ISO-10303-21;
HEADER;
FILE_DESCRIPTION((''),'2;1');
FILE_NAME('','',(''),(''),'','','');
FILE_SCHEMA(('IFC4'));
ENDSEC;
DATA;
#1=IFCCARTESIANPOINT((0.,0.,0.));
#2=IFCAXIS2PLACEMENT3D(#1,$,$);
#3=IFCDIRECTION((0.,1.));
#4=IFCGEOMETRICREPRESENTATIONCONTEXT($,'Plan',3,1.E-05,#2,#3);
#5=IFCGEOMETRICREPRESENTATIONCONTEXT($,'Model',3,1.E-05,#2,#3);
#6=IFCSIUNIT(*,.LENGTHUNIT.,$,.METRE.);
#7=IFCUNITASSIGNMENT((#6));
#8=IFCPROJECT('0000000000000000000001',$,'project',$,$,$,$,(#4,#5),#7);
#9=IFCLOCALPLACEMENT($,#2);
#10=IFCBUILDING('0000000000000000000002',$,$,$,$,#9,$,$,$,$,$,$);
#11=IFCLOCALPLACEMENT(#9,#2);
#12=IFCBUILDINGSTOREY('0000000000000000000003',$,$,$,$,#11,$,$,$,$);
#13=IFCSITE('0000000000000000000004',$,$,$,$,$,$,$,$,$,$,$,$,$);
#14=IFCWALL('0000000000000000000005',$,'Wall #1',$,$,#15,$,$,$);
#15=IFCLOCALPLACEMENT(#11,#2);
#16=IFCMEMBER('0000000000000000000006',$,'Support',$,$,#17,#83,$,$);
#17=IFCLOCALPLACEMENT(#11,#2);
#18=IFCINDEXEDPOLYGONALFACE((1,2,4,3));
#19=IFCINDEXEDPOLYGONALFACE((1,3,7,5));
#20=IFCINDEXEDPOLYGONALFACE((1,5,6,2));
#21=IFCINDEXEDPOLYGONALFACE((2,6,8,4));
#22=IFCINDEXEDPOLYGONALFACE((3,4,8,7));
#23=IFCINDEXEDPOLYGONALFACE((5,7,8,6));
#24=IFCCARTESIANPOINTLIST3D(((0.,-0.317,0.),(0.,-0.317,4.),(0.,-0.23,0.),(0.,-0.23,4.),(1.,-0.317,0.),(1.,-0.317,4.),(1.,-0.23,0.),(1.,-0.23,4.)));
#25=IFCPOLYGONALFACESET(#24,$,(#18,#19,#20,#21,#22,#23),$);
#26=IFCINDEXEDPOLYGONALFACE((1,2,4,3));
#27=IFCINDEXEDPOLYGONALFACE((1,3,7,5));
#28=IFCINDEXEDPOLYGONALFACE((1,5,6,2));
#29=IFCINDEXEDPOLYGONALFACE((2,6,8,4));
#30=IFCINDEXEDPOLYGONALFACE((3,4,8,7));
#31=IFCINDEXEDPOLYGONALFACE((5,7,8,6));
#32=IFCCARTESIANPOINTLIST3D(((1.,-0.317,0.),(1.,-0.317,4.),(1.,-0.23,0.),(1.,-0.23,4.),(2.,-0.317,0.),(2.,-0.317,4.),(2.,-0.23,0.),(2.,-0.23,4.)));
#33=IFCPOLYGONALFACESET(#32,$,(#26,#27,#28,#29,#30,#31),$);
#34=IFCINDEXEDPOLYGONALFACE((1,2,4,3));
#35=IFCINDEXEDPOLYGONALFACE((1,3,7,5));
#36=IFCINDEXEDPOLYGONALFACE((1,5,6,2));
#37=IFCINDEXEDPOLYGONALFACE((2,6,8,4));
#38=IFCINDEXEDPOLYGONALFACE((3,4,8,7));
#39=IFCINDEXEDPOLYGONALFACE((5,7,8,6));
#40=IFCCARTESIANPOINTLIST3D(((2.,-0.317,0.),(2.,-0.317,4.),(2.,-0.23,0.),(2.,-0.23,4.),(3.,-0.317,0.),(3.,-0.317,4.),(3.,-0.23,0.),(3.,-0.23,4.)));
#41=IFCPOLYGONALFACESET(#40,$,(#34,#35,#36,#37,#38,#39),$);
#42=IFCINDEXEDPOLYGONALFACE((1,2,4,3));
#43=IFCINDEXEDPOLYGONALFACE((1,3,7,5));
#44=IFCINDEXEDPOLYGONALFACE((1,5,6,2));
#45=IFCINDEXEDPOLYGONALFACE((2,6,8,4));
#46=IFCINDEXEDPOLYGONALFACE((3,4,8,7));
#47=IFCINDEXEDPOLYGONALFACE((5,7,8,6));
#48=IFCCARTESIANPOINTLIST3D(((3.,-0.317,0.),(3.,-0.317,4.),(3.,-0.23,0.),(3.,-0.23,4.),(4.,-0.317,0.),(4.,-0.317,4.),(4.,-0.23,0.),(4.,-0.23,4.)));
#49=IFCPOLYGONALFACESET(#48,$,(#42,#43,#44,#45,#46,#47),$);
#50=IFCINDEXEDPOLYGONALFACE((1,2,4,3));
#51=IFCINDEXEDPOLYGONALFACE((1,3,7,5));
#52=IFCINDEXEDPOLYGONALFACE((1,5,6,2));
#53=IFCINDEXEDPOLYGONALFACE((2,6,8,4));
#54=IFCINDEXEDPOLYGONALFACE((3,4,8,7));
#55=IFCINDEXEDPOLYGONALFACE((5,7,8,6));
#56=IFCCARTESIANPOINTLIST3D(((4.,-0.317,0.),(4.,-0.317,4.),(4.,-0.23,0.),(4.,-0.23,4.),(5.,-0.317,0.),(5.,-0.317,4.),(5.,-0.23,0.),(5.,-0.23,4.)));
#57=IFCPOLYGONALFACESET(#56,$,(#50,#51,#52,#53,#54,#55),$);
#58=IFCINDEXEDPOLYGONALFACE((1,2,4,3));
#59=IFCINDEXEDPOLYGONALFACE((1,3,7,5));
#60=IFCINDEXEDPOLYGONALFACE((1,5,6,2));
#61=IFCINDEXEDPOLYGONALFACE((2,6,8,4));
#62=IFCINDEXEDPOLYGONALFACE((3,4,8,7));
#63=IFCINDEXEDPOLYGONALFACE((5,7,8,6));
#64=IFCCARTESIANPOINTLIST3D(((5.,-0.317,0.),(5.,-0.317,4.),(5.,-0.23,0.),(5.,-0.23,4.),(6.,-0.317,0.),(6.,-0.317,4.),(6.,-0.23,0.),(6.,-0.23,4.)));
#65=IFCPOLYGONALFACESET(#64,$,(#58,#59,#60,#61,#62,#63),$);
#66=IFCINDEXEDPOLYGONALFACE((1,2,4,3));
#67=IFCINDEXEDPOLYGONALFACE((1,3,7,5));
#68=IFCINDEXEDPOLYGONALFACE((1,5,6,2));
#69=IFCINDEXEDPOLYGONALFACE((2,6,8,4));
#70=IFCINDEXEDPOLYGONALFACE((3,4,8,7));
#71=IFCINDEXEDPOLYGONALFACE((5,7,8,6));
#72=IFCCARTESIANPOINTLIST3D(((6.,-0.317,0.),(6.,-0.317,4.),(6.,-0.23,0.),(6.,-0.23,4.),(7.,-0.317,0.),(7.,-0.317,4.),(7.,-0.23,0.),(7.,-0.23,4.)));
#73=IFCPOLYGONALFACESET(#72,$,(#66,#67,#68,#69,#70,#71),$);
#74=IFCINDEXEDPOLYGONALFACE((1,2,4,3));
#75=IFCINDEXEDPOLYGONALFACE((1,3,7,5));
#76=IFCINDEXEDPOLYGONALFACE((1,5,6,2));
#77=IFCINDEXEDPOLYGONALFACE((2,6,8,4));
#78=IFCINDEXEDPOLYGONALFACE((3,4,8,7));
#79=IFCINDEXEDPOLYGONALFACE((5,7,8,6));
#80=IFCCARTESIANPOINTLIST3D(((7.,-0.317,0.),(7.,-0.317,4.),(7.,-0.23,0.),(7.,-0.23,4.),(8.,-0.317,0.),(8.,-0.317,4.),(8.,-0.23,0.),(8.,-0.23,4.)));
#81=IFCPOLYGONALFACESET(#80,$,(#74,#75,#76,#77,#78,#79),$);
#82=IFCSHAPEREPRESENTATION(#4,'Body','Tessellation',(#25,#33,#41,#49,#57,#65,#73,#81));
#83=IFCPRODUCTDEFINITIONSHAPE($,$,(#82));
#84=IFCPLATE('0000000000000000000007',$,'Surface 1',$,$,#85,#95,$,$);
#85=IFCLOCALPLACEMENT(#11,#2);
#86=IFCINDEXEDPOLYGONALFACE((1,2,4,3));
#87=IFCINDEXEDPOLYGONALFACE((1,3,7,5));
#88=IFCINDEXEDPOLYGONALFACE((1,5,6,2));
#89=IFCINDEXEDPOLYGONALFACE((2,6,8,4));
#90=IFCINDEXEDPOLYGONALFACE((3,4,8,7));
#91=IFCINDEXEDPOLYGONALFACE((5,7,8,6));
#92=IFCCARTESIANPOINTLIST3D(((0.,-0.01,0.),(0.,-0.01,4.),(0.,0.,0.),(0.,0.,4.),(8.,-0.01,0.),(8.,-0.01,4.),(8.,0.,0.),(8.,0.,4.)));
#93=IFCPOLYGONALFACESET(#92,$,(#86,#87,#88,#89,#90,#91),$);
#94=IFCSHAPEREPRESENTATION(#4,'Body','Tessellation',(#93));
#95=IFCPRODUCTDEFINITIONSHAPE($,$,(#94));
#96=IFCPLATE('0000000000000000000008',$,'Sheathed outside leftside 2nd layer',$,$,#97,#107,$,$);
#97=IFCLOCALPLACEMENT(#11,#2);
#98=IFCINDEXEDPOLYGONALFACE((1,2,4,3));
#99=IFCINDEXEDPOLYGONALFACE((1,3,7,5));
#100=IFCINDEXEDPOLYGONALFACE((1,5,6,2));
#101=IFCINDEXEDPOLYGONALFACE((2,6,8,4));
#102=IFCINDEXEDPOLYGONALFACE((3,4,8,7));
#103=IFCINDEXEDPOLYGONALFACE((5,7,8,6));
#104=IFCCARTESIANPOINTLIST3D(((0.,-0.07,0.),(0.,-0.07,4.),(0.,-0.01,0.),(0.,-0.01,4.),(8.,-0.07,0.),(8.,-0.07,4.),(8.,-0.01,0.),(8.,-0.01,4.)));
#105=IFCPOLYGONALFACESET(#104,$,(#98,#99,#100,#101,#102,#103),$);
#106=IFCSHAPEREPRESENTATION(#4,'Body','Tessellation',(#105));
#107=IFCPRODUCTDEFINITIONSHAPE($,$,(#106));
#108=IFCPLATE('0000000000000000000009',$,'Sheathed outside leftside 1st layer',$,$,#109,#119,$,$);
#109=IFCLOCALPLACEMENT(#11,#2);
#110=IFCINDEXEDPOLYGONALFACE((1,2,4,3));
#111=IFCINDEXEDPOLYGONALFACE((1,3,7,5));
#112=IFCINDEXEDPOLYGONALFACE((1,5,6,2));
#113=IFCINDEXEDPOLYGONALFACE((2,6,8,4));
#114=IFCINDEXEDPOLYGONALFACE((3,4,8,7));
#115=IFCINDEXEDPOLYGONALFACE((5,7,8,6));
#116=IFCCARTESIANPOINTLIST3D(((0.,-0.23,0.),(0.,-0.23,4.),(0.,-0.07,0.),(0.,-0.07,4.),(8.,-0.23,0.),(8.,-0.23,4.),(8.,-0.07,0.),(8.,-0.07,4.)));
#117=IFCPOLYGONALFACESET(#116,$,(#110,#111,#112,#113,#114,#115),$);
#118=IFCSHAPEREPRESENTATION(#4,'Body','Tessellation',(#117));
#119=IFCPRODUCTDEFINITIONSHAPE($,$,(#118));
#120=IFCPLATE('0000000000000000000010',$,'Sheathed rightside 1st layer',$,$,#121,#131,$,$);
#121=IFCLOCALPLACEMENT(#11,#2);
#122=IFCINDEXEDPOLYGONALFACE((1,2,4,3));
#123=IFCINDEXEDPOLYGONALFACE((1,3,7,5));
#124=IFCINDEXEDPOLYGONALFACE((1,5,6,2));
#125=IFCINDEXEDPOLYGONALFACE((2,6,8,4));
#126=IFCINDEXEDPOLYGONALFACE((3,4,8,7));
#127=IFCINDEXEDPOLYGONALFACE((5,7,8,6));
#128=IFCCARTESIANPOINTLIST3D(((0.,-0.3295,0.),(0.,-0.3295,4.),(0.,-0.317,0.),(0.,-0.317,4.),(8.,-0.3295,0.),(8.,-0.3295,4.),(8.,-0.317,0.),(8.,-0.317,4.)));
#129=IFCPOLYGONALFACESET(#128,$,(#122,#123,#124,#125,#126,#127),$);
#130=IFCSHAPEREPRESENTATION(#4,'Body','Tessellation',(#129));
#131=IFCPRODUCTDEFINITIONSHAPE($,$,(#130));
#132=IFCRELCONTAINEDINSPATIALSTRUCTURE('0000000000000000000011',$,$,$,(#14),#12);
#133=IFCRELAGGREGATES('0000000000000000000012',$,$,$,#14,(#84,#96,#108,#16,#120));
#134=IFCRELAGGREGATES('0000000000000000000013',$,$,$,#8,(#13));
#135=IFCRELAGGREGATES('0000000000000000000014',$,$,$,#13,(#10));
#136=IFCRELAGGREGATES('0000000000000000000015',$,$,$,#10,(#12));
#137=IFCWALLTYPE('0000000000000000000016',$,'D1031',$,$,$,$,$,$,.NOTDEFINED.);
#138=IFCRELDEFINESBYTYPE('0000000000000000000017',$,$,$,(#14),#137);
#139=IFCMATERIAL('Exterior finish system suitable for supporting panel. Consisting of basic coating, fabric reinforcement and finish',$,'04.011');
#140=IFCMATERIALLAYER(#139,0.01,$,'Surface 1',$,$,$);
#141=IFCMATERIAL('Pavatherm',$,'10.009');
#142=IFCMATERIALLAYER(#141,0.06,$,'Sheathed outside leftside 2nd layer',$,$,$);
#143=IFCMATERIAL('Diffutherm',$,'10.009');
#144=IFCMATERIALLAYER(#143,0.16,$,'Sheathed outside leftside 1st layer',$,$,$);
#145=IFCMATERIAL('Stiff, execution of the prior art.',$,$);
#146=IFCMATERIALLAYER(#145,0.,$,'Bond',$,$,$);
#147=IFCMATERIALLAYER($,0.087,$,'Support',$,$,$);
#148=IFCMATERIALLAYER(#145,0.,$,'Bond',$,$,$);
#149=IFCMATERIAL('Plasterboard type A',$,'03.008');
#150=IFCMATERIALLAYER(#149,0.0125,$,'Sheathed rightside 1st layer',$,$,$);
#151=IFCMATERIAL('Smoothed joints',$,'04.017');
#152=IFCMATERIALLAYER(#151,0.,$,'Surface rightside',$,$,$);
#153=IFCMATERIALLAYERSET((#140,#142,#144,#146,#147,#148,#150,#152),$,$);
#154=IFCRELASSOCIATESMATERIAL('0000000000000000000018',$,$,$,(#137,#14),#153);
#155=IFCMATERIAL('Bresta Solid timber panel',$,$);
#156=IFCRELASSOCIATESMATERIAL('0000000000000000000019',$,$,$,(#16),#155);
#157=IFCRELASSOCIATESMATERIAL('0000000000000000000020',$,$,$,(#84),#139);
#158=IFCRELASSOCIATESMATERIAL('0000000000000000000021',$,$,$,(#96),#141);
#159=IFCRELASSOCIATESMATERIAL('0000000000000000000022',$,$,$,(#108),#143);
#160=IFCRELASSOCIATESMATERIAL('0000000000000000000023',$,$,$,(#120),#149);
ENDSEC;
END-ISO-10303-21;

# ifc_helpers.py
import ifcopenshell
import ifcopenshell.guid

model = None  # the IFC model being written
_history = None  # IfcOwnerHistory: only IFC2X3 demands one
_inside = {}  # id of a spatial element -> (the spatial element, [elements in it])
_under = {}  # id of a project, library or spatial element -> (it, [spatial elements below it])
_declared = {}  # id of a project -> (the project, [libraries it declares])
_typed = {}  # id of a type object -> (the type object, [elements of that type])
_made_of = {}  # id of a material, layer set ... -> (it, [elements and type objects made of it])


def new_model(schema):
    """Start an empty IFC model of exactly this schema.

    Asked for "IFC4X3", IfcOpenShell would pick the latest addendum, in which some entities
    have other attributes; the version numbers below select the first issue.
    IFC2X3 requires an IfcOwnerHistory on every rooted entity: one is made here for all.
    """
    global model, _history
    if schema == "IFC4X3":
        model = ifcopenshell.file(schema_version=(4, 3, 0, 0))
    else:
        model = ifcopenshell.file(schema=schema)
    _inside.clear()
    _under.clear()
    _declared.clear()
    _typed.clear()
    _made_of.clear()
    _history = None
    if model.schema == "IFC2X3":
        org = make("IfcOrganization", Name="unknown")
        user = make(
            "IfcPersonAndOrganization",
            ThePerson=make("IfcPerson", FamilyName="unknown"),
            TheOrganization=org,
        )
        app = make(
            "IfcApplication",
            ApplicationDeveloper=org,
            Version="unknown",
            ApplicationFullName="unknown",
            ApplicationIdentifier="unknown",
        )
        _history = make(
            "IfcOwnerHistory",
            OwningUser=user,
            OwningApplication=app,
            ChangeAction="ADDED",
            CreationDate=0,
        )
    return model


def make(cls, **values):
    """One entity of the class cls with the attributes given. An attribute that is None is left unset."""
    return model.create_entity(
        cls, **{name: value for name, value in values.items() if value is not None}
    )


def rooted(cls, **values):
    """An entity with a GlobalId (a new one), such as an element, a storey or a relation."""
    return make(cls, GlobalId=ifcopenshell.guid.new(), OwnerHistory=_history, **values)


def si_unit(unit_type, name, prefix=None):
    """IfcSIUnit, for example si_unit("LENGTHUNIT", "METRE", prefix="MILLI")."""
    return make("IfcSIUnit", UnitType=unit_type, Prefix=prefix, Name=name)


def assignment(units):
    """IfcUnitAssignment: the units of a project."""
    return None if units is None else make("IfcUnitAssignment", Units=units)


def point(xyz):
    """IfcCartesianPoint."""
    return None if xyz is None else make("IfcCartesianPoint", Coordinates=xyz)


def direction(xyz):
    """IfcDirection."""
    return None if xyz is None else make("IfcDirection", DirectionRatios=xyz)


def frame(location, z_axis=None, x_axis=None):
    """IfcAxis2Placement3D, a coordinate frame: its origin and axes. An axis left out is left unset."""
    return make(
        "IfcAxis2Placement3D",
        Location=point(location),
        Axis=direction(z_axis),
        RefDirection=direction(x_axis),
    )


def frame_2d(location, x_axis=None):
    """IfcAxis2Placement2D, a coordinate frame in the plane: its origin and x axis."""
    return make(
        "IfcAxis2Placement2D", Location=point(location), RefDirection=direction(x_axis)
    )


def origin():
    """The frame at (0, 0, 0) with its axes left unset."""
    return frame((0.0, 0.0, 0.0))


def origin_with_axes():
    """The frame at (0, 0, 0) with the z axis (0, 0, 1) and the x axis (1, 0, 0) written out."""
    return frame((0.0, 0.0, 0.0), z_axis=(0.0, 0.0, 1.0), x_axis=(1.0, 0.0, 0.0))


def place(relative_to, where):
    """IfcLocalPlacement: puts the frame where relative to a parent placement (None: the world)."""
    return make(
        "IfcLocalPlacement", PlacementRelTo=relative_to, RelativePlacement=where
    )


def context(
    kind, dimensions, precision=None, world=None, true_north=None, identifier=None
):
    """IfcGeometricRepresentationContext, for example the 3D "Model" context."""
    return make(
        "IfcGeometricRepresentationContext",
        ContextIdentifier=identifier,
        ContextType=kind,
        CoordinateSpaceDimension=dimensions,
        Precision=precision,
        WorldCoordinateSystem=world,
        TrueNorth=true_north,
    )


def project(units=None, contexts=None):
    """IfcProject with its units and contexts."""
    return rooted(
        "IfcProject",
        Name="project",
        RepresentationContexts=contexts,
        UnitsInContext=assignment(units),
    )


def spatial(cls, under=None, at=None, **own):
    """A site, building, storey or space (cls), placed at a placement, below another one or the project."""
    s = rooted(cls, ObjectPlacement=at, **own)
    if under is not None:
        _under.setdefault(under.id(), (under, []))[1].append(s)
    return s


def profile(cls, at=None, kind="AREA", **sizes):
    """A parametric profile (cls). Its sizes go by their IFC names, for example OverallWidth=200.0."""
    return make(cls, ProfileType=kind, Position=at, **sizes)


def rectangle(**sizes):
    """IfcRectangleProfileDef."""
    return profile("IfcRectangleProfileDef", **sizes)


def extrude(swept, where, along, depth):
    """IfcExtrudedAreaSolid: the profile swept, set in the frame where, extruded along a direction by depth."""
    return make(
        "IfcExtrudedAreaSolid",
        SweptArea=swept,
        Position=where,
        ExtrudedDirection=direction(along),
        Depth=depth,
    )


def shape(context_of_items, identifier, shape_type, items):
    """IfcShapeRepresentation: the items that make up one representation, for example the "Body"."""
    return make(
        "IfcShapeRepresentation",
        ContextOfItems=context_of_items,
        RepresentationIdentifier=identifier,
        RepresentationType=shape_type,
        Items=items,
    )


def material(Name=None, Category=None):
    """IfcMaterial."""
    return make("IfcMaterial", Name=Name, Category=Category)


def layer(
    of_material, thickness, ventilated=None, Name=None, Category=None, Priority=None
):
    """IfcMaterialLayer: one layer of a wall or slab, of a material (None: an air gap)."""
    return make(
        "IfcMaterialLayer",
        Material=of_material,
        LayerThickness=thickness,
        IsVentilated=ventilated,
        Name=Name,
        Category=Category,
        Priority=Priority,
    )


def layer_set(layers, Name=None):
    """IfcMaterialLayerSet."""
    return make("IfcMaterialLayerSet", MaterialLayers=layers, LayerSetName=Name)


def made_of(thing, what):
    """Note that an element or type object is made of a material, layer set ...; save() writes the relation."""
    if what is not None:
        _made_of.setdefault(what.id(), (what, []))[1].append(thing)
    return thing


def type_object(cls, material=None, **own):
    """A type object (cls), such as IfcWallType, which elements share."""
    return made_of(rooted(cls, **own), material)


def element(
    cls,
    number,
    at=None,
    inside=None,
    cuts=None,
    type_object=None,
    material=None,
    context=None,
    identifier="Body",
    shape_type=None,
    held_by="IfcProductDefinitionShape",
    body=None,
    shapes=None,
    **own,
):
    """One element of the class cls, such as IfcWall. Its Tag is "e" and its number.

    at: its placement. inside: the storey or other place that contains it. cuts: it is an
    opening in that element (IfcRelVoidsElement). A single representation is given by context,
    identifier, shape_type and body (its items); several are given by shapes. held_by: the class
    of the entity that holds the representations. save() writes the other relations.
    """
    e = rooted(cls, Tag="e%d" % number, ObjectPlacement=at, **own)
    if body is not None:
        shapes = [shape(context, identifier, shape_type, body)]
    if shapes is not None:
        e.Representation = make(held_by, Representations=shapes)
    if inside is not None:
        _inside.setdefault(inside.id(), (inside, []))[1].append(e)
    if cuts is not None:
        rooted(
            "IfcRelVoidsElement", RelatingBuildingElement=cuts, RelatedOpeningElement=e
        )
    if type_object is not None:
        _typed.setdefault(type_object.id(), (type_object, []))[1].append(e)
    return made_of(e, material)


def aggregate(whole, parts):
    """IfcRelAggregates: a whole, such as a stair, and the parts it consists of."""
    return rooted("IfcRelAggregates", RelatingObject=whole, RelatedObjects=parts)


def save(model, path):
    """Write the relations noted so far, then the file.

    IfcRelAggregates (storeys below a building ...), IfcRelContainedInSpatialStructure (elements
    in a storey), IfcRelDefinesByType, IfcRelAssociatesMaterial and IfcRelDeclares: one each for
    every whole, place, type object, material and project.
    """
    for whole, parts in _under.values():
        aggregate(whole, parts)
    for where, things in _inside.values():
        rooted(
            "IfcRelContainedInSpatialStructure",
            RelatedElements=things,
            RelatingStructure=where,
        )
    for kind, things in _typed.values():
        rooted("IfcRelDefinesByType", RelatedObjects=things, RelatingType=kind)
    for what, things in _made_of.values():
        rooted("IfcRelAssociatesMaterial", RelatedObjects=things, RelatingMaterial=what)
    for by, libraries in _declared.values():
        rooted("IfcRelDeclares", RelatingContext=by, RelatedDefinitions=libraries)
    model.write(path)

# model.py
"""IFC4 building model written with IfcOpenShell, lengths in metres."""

from ifc_helpers import new_model, si_unit, direction, frame, frame_2d, origin, origin_with_axes, place, context, project, spatial, rectangle, extrude, material, layer, layer_set, type_object, element, aggregate, save


model = new_model("IFC4")

# Units and contexts
plan_context = context("Plan", 3, precision=1e-05, world=origin(), true_north=direction((0.0, 1.0)))
model_context = context("Model", 3, precision=1e-05, world=origin(), true_north=direction((0.0, 1.0)))
ifc_project = project(units=[si_unit("LENGTHUNIT", "METRE")], contexts=[plan_context, model_context])

# Site, building, storey
site = spatial("IfcSite", under=ifc_project)
building_placement = place(None, origin())
building = spatial("IfcBuilding", under=site, at=building_placement)
storey_placement = place(building_placement, origin())
storey = spatial("IfcBuildingStorey", under=building, at=storey_placement)

# Wall, member, plates
ifc_material_1 = material(Name="Exterior finish system suitable for supporting panel. Consisting of basic coating, fabric reinforcement and finish", Category="04.011")
ifc_layer_1 = layer(ifc_material_1, 0.01, Name="Surface 1")
ifc_material_2 = material(Name="Pavatherm", Category="10.009")
ifc_layer_2 = layer(ifc_material_2, 0.06, Name="Sheathed outside leftside 2nd layer")
ifc_material_3 = material(Name="Diffutherm", Category="10.009")
ifc_layer_3 = layer(ifc_material_3, 0.16, Name="Sheathed outside leftside 1st layer")
ifc_material_4 = material(Name="Stiff, execution of the prior art.")
ifc_layer_4 = layer(ifc_material_4, 0.0, Name="Bond")
ifc_layer_5 = layer(None, 0.087, Name="Support")
ifc_layer_6 = layer(ifc_material_4, 0.0, Name="Bond")
ifc_material_5 = material(Name="Plasterboard type A", Category="03.008")
ifc_layer_7 = layer(ifc_material_5, 0.0125, Name="Sheathed rightside 1st layer")
ifc_material_6 = material(Name="Smoothed joints", Category="04.017")
ifc_layer_8 = layer(ifc_material_6, 0.0, Name="Surface rightside")
ifc_layer_set = layer_set([ifc_layer_1, ifc_layer_2, ifc_layer_3, ifc_layer_4, ifc_layer_5, ifc_layer_6, ifc_layer_7, ifc_layer_8])
wall_type = type_object("IfcWallType", Name="D1031", PredefinedType="NOTDEFINED", material=ifc_layer_set)
wall_placement = place(None, frame((0.0, 0.0, 0.0), z_axis=(0.0, -1.0, 0.0), x_axis=(1.0, 0.0, 0.0)))
wall = element("IfcWall", 1, at=wall_placement, inside=storey, type_object=wall_type, material=ifc_layer_set, Name="Wall #1")
ifc_material_7 = material(Name="Bresta Solid timber panel")
member_placement = place(wall_placement, origin())
member = element("IfcMember", 2, at=member_placement, material=ifc_material_7, Name="Support", context=plan_context, shape_type="SweptSolid", body=[
    extrude(rectangle(XDim=1.0, YDim=0.087, at=frame_2d((0.5, 0.0435), x_axis=(1.0, 0.0))), frame((0.0, 4.0, 0.23), z_axis=(0.0, -1.0, 0.0), x_axis=(1.0, 0.0, 0.0)), (0.0, 0.0, 1.0), 4.0),
    extrude(rectangle(XDim=1.0, YDim=0.087, at=frame_2d((0.5, 0.0435), x_axis=(1.0, 0.0))), frame((1.0, 4.0, 0.23), z_axis=(0.0, -1.0, 0.0), x_axis=(1.0, 0.0, 0.0)), (0.0, 0.0, 1.0), 4.0),
    extrude(rectangle(XDim=1.0, YDim=0.087, at=frame_2d((0.5, 0.0435), x_axis=(1.0, 0.0))), frame((2.0, 4.0, 0.23), z_axis=(0.0, -1.0, 0.0), x_axis=(1.0, 0.0, 0.0)), (0.0, 0.0, 1.0), 4.0),
    extrude(rectangle(XDim=1.0, YDim=0.087, at=frame_2d((0.5, 0.0435), x_axis=(1.0, 0.0))), frame((3.0, 4.0, 0.23), z_axis=(0.0, -1.0, 0.0), x_axis=(1.0, 0.0, 0.0)), (0.0, 0.0, 1.0), 4.0),
    extrude(rectangle(XDim=1.0, YDim=0.087, at=frame_2d((0.5, 0.0435), x_axis=(1.0, 0.0))), frame((4.0, 4.0, 0.23), z_axis=(0.0, -1.0, 0.0), x_axis=(1.0, 0.0, 0.0)), (0.0, 0.0, 1.0), 4.0),
    extrude(rectangle(XDim=1.0, YDim=0.087, at=frame_2d((0.5, 0.0435), x_axis=(1.0, 0.0))), frame((5.0, 4.0, 0.23), z_axis=(0.0, -1.0, 0.0), x_axis=(1.0, 0.0, 0.0)), (0.0, 0.0, 1.0), 4.0),
    extrude(rectangle(XDim=1.0, YDim=0.087, at=frame_2d((0.5, 0.0435), x_axis=(1.0, 0.0))), frame((6.0, 4.0, 0.23), z_axis=(0.0, -1.0, 0.0), x_axis=(1.0, 0.0, 0.0)), (0.0, 0.0, 1.0), 4.0),
    extrude(rectangle(XDim=1.0, YDim=0.087, at=frame_2d((0.5, 0.0435), x_axis=(1.0, 0.0))), frame((7.0, 4.0, 0.23), z_axis=(0.0, -1.0, 0.0), x_axis=(1.0, 0.0, 0.0)), (0.0, 0.0, 1.0), 4.0),
])
plate_1_placement = place(wall_placement, origin())
plate_1 = element("IfcPlate", 3, at=plate_1_placement, material=ifc_material_1, Name="Surface 1", context=plan_context, shape_type="SweptSolid", body=[
    extrude(rectangle(XDim=8.0, YDim=4.0, at=frame_2d((4.0, 2.0), x_axis=(1.0, 0.0))), origin_with_axes(), (0.0, 0.0, 1.0), 0.01),
])
plate_2_placement = place(wall_placement, origin())
plate_2 = element("IfcPlate", 4, at=plate_2_placement, material=ifc_material_2, Name="Sheathed outside leftside 2nd layer", context=plan_context, shape_type="SweptSolid", body=[
    extrude(rectangle(XDim=8.0, YDim=4.0, at=frame_2d((4.0, 2.0), x_axis=(1.0, 0.0))), frame((0.0, 0.0, 0.01), z_axis=(0.0, 0.0, 1.0), x_axis=(1.0, 0.0, 0.0)), (0.0, 0.0, 1.0), 0.06),
])
plate_3_placement = place(wall_placement, origin())
plate_3 = element("IfcPlate", 5, at=plate_3_placement, material=ifc_material_3, Name="Sheathed outside leftside 1st layer", context=plan_context, shape_type="SweptSolid", body=[
    extrude(rectangle(XDim=8.0, YDim=4.0, at=frame_2d((4.0, 2.0), x_axis=(1.0, 0.0))), frame((0.0, 0.0, 0.07), z_axis=(0.0, 0.0, 1.0), x_axis=(1.0, 0.0, 0.0)), (0.0, 0.0, 1.0), 0.16),
])
plate_4_placement = place(wall_placement, origin())
plate_4 = element("IfcPlate", 6, at=plate_4_placement, material=ifc_material_5, Name="Sheathed rightside 1st layer", context=plan_context, shape_type="SweptSolid", body=[
    extrude(rectangle(XDim=8.0, YDim=4.0, at=frame_2d((4.0, 2.0), x_axis=(1.0, 0.0))), frame((0.0, 0.0, 0.317), z_axis=(0.0, 0.0, 1.0), x_axis=(1.0, 0.0, 0.0)), (0.0, 0.0, 1.0), 0.0125),
])
aggregate(wall, [plate_1, plate_2, plate_3, member, plate_4])

save(model, "model.ifc")
